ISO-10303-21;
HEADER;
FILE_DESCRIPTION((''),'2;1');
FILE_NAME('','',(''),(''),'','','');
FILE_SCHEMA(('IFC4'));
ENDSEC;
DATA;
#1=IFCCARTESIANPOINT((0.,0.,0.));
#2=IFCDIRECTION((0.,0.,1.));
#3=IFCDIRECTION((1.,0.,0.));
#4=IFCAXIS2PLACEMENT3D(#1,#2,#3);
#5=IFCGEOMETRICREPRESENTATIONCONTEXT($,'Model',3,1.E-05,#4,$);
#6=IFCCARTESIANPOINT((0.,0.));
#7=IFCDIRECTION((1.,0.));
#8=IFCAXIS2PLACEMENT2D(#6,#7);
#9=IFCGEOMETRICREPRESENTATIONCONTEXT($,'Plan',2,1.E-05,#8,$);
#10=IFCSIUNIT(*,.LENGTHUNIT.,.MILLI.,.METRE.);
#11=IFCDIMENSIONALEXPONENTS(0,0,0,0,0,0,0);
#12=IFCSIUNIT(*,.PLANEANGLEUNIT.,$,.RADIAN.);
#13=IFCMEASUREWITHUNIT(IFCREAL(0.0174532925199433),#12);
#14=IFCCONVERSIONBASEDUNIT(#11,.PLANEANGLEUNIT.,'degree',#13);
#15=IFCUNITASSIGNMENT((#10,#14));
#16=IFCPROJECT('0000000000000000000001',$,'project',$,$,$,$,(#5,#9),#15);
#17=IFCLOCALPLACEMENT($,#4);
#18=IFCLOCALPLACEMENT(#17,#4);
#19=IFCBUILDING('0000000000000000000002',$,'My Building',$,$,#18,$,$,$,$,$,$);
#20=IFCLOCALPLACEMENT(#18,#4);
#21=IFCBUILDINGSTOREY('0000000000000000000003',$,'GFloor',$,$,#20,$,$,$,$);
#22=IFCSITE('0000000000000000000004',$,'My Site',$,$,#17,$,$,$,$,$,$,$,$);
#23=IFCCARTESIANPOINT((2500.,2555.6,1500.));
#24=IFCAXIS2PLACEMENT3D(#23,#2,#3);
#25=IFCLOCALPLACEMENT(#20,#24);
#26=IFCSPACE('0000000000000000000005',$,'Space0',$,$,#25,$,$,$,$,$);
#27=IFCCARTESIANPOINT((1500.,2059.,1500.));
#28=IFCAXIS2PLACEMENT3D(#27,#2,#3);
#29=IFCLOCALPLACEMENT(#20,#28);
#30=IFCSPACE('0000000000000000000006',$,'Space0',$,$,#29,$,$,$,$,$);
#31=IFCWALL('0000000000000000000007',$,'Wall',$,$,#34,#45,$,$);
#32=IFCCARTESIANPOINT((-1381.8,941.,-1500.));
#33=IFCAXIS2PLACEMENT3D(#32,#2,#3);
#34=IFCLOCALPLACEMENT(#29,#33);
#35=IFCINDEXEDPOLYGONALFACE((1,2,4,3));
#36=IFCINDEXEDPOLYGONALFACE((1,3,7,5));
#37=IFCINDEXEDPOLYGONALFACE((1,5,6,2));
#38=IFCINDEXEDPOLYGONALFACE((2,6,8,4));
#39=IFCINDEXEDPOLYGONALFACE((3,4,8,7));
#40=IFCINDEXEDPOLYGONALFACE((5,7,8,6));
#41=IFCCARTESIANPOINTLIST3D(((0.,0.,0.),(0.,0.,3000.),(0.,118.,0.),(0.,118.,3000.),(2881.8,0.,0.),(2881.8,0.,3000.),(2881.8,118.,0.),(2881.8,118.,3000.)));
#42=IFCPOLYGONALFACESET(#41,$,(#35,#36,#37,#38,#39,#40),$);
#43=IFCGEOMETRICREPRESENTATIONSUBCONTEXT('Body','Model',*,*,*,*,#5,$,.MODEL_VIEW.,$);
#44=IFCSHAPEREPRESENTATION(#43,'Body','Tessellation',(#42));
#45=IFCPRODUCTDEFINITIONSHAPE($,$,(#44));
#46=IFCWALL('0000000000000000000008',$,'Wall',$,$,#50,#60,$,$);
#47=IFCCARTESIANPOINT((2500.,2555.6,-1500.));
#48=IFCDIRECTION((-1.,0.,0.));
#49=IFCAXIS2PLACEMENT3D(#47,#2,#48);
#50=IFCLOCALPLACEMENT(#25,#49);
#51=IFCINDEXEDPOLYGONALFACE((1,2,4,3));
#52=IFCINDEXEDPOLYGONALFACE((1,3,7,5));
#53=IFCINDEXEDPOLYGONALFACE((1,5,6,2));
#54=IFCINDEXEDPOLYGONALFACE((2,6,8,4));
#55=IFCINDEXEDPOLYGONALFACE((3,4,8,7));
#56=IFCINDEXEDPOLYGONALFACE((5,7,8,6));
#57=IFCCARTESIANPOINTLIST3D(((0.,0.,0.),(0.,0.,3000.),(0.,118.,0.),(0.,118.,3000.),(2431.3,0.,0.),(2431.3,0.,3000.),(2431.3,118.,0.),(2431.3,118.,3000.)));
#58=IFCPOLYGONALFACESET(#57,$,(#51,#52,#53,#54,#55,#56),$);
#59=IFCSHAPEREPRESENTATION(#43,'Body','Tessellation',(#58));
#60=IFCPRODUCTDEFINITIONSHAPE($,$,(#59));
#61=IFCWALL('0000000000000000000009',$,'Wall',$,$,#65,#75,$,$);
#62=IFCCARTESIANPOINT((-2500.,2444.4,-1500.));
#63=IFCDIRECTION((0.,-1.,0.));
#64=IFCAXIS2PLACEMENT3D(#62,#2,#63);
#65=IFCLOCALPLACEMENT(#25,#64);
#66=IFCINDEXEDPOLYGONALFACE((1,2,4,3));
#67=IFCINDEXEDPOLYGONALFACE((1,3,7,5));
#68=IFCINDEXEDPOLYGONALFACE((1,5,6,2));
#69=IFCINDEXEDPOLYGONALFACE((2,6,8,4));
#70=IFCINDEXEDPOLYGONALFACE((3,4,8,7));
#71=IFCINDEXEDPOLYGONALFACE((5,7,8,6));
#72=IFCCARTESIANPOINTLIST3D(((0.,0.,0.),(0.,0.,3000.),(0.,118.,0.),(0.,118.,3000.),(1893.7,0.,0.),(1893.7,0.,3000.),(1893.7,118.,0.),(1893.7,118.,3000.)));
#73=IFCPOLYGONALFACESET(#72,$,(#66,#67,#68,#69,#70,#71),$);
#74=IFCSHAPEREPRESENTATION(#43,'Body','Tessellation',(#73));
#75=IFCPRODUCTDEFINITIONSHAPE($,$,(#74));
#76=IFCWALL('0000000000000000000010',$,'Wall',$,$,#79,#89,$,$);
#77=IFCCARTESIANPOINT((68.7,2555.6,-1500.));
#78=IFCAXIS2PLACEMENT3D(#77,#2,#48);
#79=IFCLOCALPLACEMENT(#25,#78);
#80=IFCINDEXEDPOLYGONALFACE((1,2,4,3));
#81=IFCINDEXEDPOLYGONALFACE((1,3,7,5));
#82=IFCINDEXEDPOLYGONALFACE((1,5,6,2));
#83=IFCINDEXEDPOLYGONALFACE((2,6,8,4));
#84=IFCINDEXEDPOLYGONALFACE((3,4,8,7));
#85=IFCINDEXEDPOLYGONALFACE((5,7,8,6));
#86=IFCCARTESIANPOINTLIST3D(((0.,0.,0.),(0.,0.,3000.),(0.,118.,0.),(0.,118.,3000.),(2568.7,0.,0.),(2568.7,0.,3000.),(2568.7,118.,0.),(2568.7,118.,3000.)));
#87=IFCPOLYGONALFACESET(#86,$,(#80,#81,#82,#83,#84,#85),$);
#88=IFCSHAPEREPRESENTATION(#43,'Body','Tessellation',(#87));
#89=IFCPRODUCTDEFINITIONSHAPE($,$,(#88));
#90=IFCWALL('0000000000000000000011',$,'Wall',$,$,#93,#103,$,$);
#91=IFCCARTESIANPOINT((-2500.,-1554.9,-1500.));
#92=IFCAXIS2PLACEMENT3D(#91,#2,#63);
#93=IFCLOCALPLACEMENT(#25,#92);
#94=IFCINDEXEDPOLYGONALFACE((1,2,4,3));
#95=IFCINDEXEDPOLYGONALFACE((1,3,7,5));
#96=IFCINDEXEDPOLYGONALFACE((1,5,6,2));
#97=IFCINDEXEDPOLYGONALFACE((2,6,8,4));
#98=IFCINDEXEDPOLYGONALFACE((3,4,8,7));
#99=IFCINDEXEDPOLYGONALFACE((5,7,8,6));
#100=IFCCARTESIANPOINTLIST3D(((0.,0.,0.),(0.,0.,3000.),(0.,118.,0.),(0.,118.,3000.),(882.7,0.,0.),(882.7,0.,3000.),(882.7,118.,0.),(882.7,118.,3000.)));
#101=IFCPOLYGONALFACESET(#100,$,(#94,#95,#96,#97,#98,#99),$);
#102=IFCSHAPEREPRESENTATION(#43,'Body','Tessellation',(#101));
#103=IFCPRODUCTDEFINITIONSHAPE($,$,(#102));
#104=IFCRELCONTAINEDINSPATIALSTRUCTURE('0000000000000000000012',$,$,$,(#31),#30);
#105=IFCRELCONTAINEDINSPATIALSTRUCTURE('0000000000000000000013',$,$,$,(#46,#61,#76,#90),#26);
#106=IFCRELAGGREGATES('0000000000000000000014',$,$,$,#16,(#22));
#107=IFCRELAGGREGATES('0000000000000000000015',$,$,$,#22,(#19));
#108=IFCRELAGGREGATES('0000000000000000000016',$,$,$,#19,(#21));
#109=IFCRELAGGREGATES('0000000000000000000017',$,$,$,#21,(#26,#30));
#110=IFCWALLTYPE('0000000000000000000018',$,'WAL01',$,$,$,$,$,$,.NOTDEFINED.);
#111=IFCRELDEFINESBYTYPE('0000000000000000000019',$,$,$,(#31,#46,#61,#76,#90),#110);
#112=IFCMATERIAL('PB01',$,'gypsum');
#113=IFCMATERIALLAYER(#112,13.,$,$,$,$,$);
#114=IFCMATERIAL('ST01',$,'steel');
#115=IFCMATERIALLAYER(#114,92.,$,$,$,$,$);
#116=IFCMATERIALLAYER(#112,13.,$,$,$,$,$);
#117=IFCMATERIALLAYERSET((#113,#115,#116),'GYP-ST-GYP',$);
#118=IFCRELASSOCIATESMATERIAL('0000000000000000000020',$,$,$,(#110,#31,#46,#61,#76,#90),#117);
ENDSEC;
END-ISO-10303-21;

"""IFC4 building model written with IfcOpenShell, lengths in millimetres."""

from ifc_helpers import new_model, entity, si_unit, converted_unit, frame, origin_with_axes, origin_2d_with_axis, place, context, subcontext, project, spatial, indexed_curve, outline, extrude, material, layer, layer_set, layer_usage, type_object, element, save


model = new_model("IFC4")

# Units and contexts
model_context = context("Model", 3, precision=1e-05, world=origin_with_axes())
plan_context = context("Plan", 2, precision=1e-05, world=origin_2d_with_axis())
body_context_1 = subcontext(model_context, "Body", "Model", "MODEL_VIEW")
ifc_project = project(units=[si_unit("LENGTHUNIT", "METRE", prefix="MILLI"), converted_unit("PLANEANGLEUNIT", "degree", entity("IfcReal", 0.0174532925199433), si_unit("PLANEANGLEUNIT", "RADIAN"), dimensions=[0, 0, 0, 0, 0, 0, 0])], contexts=[model_context, plan_context])

# Site, building, storey, space
site_placement = place(None, origin_with_axes())
site = spatial("IfcSite", under=ifc_project, at=site_placement, Name="My Site")
building_placement = place(site_placement, origin_with_axes())
building = spatial("IfcBuilding", under=site, at=building_placement, Name="My Building")
storey_placement = place(building_placement, origin_with_axes())
storey = spatial("IfcBuildingStorey", under=building, at=storey_placement, Name="GFloor")
space_1_placement = place(storey_placement, frame((2500.0, 2555.6, 1500.0), z_axis=(0.0, 0.0, 1.0), x_axis=(1.0, 0.0, 0.0)))
space_1 = spatial("IfcSpace", under=storey, at=space_1_placement, Name="Space0")

# Shared definitions
ifc_material_1 = material(Name="PB01", Category="gypsum")
ifc_layer_1 = layer(ifc_material_1, 13.0)
ifc_material_2 = material(Name="ST01", Category="steel")
ifc_layer_2 = layer(ifc_material_2, 92.0)
ifc_layer_3 = layer(ifc_material_1, 13.0)
ifc_layer_set_1 = layer_set([ifc_layer_1, ifc_layer_2, ifc_layer_3], Name="GYP-ST-GYP")
wall_type_1 = type_object("IfcWallType", Name="WAL01", PredefinedType="NOTDEFINED", material=ifc_layer_set_1)

# Shared definitions
space_2_placement = place(storey_placement, frame((1500.0, 2059.0, 1500.0), z_axis=(0.0, 0.0, 1.0), x_axis=(1.0, 0.0, 0.0)))
space_2 = spatial("IfcSpace", under=storey, at=space_2_placement, Name="Space0")

# Walls
ifc_layer_usage_1 = layer_usage(ifc_layer_set_1, "AXIS2", "POSITIVE", 0.0)
wall_1_placement = place(space_2_placement, frame((-1381.8, 941.0, -1500.0), z_axis=(0.0, 0.0, 1.0), x_axis=(1.0, 0.0, 0.0)))
element("IfcWall", 1, at=wall_1_placement, inside=space_2, type_object=wall_type_1, material=ifc_layer_usage_1, Name="Wall", context=body_context_1, shape_type="SweptSolid", body=[
    extrude(outline(indexed_curve([(0.0, 0.0), (0.0, 118.0), (2881.8, 118.0), (2881.8, 0.0), (0.0, 0.0)], self_intersect=False)), origin_with_axes(), (0.0, 0.0, 1.0), 3000.0),
])
ifc_layer_usage_2 = layer_usage(ifc_layer_set_1, "AXIS2", "POSITIVE", 0.0)
wall_2_placement = place(space_1_placement, frame((2500.0, 2555.6, -1500.0), z_axis=(0.0, 0.0, 1.0), x_axis=(-1.0, 0.0, 0.0)))
element("IfcWall", 2, at=wall_2_placement, inside=space_1, type_object=wall_type_1, material=ifc_layer_usage_2, Name="Wall", context=body_context_1, shape_type="SweptSolid", body=[
    extrude(outline(indexed_curve([(0.0, 0.0), (0.0, 118.0), (2431.3, 118.0), (2431.3, 0.0), (0.0, 0.0)], self_intersect=False)), origin_with_axes(), (0.0, 0.0, 1.0), 3000.0),
])
ifc_layer_usage_3 = layer_usage(ifc_layer_set_1, "AXIS2", "POSITIVE", 0.0)
wall_3_placement = place(space_1_placement, frame((-2500.0, 2444.4, -1500.0), z_axis=(0.0, 0.0, 1.0), x_axis=(0.0, -1.0, 0.0)))
element("IfcWall", 3, at=wall_3_placement, inside=space_1, type_object=wall_type_1, material=ifc_layer_usage_3, Name="Wall", context=body_context_1, shape_type="SweptSolid", body=[
    extrude(outline(indexed_curve([(0.0, 0.0), (0.0, 118.0), (1893.7, 118.0), (1893.7, 0.0), (0.0, 0.0)], self_intersect=False)), origin_with_axes(), (0.0, 0.0, 1.0), 3000.0),
])
ifc_layer_usage_4 = layer_usage(ifc_layer_set_1, "AXIS2", "POSITIVE", 0.0)
wall_4_placement = place(space_1_placement, frame((68.7, 2555.6, -1500.0), z_axis=(0.0, 0.0, 1.0), x_axis=(-1.0, 0.0, 0.0)))
element("IfcWall", 4, at=wall_4_placement, inside=space_1, type_object=wall_type_1, material=ifc_layer_usage_4, Name="Wall", context=body_context_1, shape_type="SweptSolid", body=[
    extrude(outline(indexed_curve([(0.0, 0.0), (0.0, 118.0), (2568.7, 118.0), (2568.7, 0.0), (0.0, 0.0)], self_intersect=False)), origin_with_axes(), (0.0, 0.0, 1.0), 3000.0),
])
ifc_layer_usage_5 = layer_usage(ifc_layer_set_1, "AXIS2", "POSITIVE", 0.0)
wall_5_placement = place(space_1_placement, frame((-2500.0, -1554.9, -1500.0), z_axis=(0.0, 0.0, 1.0), x_axis=(0.0, -1.0, 0.0)))
element("IfcWall", 5, at=wall_5_placement, inside=space_1, type_object=wall_type_1, material=ifc_layer_usage_5, Name="Wall", context=body_context_1, shape_type="SweptSolid", body=[
    extrude(outline(indexed_curve([(0.0, 0.0), (0.0, 118.0), (882.7, 118.0), (882.7, 0.0), (0.0, 0.0)], self_intersect=False)), origin_with_axes(), (0.0, 0.0, 1.0), 3000.0),
])

save(model, "model.ifc")
